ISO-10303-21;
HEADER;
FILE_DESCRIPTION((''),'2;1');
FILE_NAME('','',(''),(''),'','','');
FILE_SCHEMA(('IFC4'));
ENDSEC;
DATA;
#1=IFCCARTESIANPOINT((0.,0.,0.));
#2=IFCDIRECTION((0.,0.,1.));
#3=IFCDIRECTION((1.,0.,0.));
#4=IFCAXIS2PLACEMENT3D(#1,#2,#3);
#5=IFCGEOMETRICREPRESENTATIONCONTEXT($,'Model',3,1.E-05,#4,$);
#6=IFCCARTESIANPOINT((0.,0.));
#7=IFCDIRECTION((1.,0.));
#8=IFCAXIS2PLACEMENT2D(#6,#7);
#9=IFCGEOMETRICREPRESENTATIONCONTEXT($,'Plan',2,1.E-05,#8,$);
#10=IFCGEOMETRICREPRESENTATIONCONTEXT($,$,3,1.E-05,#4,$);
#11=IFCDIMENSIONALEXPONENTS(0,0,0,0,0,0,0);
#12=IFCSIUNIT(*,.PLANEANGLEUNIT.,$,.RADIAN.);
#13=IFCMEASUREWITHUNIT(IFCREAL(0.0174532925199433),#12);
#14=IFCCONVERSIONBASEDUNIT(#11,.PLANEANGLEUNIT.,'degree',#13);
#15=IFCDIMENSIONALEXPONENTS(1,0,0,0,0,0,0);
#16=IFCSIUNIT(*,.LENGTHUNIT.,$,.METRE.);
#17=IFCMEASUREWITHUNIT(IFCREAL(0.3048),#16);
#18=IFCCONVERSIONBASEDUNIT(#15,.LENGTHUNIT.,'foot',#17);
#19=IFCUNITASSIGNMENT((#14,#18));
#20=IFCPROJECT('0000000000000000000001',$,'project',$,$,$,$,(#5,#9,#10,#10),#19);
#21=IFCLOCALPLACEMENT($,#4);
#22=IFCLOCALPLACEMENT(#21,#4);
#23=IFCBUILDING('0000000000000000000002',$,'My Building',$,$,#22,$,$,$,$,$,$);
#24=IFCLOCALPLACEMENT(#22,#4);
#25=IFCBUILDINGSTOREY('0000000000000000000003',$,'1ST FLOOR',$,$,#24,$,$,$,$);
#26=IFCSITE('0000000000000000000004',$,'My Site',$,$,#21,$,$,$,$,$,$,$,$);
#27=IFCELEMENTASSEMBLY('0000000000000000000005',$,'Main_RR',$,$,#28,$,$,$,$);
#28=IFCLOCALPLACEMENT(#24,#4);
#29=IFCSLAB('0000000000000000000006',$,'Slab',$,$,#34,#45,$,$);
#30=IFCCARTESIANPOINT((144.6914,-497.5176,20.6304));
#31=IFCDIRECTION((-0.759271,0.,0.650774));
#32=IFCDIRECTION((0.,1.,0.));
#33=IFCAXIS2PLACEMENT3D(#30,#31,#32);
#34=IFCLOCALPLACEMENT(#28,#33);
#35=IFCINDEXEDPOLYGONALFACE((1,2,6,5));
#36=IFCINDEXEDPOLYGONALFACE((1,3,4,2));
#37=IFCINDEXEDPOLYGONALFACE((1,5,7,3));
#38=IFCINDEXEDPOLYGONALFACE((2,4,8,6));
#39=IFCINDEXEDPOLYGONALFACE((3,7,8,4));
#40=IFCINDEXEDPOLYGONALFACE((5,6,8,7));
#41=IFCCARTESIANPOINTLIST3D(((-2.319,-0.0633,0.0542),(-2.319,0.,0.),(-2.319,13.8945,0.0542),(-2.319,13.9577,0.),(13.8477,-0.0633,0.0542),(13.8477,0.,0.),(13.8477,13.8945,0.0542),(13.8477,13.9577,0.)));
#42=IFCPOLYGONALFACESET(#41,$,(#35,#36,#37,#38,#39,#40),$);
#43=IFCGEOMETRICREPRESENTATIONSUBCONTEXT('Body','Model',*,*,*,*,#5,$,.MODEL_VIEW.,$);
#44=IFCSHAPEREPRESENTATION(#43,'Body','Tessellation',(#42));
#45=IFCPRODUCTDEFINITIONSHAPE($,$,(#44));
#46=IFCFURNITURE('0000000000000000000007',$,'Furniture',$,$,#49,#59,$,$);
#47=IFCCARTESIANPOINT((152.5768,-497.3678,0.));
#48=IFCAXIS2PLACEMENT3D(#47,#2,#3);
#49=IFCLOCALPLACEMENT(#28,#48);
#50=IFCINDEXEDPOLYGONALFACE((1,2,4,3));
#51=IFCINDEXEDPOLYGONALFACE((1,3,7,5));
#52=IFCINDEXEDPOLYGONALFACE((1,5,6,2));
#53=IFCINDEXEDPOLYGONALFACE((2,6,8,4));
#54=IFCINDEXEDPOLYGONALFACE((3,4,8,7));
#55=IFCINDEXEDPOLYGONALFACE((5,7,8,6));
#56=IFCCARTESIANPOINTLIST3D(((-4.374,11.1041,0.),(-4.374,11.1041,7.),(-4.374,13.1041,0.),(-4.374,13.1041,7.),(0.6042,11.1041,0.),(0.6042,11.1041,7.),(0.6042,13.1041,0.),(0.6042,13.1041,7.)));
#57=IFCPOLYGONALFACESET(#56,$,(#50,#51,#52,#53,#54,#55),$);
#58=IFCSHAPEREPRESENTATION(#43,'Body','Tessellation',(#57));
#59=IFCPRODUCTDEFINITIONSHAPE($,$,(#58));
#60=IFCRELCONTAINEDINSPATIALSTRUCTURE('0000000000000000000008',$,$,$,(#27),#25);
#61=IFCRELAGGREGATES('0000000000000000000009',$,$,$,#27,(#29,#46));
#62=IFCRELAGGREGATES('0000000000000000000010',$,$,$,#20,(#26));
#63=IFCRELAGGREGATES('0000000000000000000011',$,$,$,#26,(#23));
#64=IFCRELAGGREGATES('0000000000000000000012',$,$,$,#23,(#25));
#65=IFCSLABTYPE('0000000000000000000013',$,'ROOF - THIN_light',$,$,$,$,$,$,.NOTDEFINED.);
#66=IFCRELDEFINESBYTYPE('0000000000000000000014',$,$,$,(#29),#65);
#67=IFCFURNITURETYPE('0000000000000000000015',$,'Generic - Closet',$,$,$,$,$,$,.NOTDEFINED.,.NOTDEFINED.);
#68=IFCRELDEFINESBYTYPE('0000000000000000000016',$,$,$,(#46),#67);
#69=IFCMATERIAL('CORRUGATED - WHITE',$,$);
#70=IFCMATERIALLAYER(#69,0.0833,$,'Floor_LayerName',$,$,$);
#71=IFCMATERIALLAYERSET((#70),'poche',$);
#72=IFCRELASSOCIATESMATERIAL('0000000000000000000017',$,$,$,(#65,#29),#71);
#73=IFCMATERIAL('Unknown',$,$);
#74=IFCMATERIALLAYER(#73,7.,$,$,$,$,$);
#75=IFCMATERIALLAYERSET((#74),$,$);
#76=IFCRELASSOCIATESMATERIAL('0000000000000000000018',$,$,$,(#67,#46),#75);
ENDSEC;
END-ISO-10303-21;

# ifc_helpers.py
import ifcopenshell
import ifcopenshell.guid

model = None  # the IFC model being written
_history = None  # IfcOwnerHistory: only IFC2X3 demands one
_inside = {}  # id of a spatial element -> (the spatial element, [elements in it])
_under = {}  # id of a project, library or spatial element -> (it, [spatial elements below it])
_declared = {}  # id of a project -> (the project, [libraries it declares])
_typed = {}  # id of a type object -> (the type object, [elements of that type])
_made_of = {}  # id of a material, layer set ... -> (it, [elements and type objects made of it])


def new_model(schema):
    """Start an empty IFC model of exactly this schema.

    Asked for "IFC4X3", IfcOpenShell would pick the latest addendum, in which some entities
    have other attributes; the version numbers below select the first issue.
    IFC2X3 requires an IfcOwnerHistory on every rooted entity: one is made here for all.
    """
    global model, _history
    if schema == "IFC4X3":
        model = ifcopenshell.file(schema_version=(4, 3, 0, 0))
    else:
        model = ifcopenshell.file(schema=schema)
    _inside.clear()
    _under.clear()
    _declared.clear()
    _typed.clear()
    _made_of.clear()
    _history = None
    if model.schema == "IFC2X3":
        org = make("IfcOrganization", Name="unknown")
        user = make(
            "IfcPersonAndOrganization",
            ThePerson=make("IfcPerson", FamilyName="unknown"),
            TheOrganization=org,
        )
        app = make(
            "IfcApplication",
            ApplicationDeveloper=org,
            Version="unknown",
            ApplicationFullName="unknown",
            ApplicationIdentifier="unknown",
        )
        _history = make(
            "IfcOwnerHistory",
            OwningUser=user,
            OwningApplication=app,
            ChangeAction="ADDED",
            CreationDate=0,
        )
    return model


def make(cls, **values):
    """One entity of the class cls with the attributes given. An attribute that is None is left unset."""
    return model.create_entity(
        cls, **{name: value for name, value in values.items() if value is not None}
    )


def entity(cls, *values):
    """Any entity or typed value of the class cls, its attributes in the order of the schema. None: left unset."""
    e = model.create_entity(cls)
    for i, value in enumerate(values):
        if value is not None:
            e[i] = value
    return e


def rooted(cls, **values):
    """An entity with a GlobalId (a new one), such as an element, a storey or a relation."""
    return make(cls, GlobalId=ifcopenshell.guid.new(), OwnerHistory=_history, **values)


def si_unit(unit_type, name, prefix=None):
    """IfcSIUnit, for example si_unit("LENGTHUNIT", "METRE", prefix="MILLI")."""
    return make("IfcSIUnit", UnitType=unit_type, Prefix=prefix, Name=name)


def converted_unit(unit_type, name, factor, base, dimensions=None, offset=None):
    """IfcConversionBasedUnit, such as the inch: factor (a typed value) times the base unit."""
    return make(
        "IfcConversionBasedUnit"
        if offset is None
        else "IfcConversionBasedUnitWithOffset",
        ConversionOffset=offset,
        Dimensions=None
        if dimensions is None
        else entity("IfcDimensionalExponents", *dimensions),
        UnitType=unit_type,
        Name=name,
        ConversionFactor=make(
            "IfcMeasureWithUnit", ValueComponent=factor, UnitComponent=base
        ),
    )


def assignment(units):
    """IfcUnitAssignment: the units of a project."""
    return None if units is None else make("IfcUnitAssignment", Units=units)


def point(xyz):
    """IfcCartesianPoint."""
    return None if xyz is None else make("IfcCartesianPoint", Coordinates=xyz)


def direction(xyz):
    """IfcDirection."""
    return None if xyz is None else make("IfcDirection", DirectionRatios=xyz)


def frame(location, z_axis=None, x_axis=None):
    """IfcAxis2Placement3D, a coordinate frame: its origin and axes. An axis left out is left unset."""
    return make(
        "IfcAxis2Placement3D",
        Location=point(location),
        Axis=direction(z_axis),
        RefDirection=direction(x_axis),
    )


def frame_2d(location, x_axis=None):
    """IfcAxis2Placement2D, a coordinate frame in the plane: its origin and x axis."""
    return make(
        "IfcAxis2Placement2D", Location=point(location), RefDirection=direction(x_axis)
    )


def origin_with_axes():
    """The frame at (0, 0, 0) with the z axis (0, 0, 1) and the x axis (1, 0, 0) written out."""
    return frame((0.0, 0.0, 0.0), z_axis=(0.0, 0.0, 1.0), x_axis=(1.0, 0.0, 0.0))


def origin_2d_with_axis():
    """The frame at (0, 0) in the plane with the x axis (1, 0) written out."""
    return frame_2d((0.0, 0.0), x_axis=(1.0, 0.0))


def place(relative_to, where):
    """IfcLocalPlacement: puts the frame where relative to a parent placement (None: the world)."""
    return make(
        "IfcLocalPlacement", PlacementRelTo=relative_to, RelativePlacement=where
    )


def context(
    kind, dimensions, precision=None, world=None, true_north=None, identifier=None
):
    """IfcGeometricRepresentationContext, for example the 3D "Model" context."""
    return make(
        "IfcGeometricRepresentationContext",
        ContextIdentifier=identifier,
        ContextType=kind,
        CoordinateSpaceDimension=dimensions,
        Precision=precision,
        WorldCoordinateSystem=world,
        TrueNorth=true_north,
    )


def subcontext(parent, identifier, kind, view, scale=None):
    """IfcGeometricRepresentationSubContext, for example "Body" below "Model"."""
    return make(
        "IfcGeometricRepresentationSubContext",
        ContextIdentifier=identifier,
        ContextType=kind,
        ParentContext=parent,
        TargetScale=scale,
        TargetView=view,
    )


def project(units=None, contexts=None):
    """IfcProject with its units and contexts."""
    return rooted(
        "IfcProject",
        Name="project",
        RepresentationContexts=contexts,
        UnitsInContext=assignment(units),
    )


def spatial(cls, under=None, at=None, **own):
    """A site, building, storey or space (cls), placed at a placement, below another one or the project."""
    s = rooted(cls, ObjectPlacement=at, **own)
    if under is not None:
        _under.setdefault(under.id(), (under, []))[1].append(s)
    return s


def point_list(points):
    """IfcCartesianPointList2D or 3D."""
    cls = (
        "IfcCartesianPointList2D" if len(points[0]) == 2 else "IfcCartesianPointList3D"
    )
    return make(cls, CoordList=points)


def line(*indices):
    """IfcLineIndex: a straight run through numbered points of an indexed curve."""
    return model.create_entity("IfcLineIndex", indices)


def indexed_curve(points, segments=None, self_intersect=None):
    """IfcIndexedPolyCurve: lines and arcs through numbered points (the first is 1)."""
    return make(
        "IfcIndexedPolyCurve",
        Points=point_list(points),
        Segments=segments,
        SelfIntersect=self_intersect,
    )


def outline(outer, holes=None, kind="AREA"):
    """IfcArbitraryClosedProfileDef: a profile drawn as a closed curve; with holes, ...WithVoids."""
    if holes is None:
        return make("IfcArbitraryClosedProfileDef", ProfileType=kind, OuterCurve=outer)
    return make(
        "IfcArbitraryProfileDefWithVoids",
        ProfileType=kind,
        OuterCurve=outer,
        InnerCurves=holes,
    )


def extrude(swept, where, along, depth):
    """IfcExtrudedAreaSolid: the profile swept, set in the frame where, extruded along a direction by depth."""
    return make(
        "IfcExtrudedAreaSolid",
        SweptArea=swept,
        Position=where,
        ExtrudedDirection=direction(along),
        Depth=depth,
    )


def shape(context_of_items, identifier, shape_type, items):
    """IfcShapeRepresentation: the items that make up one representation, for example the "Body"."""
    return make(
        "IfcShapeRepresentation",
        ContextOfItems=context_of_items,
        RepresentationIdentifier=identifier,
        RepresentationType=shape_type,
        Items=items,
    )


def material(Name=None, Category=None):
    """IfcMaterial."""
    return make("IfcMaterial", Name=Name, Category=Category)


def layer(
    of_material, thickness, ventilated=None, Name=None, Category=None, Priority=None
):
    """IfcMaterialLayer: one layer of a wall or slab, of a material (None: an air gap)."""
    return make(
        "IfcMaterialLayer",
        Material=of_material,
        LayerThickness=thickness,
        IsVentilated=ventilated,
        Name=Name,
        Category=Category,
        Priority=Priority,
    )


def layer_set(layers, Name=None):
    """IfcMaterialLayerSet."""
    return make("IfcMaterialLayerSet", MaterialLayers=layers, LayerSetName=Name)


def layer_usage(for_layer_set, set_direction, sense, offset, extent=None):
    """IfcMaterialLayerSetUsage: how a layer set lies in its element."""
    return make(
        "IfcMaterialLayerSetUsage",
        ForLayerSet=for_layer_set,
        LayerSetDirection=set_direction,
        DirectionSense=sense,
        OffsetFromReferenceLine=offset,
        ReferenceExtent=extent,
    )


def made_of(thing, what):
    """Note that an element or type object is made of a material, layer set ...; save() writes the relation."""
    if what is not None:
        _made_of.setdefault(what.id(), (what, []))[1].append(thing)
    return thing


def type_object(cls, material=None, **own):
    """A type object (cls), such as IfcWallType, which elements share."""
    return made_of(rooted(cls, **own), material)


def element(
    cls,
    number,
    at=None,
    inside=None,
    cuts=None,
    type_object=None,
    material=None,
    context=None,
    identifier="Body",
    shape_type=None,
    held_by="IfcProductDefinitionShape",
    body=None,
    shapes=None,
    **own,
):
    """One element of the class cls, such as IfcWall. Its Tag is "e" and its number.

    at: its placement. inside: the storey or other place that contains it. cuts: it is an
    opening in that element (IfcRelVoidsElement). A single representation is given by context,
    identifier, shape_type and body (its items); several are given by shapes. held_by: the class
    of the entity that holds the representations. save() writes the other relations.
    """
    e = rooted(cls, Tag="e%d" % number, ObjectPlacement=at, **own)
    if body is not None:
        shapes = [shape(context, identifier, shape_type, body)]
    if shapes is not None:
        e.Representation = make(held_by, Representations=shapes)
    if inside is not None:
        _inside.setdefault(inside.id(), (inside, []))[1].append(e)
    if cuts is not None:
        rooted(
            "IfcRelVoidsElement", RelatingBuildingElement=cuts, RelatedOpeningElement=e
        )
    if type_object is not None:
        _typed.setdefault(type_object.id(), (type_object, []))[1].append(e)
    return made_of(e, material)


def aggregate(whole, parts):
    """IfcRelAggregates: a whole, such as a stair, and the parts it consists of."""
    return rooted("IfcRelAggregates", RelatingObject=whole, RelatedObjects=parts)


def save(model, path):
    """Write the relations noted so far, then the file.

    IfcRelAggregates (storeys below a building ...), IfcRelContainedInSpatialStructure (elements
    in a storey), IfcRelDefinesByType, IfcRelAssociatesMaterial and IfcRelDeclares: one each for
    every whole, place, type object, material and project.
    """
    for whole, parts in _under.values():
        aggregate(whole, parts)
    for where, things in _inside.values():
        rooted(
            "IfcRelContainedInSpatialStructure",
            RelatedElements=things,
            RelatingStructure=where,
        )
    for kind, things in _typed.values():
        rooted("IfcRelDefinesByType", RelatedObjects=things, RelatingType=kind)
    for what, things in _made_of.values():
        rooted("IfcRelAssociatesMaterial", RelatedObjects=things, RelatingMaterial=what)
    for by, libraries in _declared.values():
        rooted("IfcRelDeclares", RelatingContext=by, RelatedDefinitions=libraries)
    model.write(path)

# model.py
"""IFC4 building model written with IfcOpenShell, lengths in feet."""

from ifc_helpers import new_model, entity, si_unit, converted_unit, frame, origin_with_axes, origin_2d_with_axis, place, context, subcontext, project, spatial, line, indexed_curve, outline, extrude, material, layer, layer_set, layer_usage, type_object, element, aggregate, save


model = new_model("IFC4")

# Units and contexts
model_context = context("Model", 3, precision=1e-05, world=origin_with_axes())
plan_context = context("Plan", 2, precision=1e-05, world=origin_2d_with_axis())
context_of_model = context(None, 3, precision=1e-05, world=origin_with_axes())
body_context = subcontext(model_context, "Body", "Model", "MODEL_VIEW")
ifc_project = project(units=[converted_unit("PLANEANGLEUNIT", "degree", entity("IfcReal", 0.0174532925199433), si_unit("PLANEANGLEUNIT", "RADIAN"), dimensions=[0, 0, 0, 0, 0, 0, 0]), converted_unit("LENGTHUNIT", "foot", entity("IfcReal", 0.3048), si_unit("LENGTHUNIT", "METRE"), dimensions=[1, 0, 0, 0, 0, 0, 0])], contexts=[model_context, plan_context, context_of_model, context_of_model])

# Site, building, storey
site_placement = place(None, origin_with_axes())
site = spatial("IfcSite", under=ifc_project, at=site_placement, Name="My Site")
building_placement = place(site_placement, origin_with_axes())
building = spatial("IfcBuilding", under=site, at=building_placement, Name="My Building")
storey_placement = place(building_placement, origin_with_axes())
storey = spatial("IfcBuildingStorey", under=building, at=storey_placement, Name="1ST FLOOR")

# Element assembly, slab, furniture
assembly_placement = place(storey_placement, origin_with_axes())
assembly = element("IfcElementAssembly", 1, at=assembly_placement, inside=storey, Name="Main_RR")
ifc_material_1 = material(Name="Unknown")
ifc_material_2 = material(Name="CORRUGATED - WHITE")
ifc_layer_1 = layer(ifc_material_2, 0.0833, Name="Floor_LayerName")
ifc_layer_set_1 = layer_set([ifc_layer_1], Name="poche")
ifc_layer_usage_1 = layer_usage(ifc_layer_set_1, "AXIS3", "POSITIVE", 0.0)
slab_type = type_object("IfcSlabType", Name="ROOF - THIN_light", PredefinedType="NOTDEFINED", material=ifc_layer_set_1)
slab_placement = place(assembly_placement, frame((144.6914, -497.5176, 20.6304), z_axis=(-0.759271, 0.0, 0.650774), x_axis=(0.0, 1.0, 0.0)))
slab = element("IfcSlab", 2, at=slab_placement, type_object=slab_type, material=ifc_layer_usage_1, Name="Slab", context=body_context, shape_type="SweptSolid", body=[
    extrude(outline(indexed_curve([(13.8477, 13.9577), (13.8477, 0.0), (-2.319, 0.0), (-2.319, 13.9577)], segments=[line(3, 2), line(2, 1), line(1, 4), line(4, 3)], self_intersect=False)), None, (0.0, -0.759271, 0.650774), 0.0833),
])
ifc_layer_2 = layer(ifc_material_1, 7.0)
ifc_layer_set_2 = layer_set([ifc_layer_2])
ifc_layer_usage_2 = layer_usage(ifc_layer_set_2, "AXIS3", "POSITIVE", 0.0)
furniture_type = type_object("IfcFurnitureType", Name="Generic - Closet", AssemblyPlace="NOTDEFINED", PredefinedType="NOTDEFINED", material=ifc_layer_set_2)
furniture_placement = place(assembly_placement, frame((152.5768, -497.3678, 0.0), z_axis=(0.0, 0.0, 1.0), x_axis=(1.0, 0.0, 0.0)))
furniture = element("IfcFurniture", 3, at=furniture_placement, type_object=furniture_type, material=ifc_layer_usage_2, Name="Furniture", context=body_context, shape_type="SweptSolid", body=[
    extrude(outline(indexed_curve([(-4.374, 13.1041), (-4.374, 11.1041), (0.6042, 11.1041), (0.6042, 13.1041)], segments=[line(4, 1), line(1, 2), line(2, 3), line(3, 4)], self_intersect=False)), None, (0.0, 0.0, 1.0), 7.0),
])
aggregate(assembly, [slab, furniture])

save(model, "model.ifc")
